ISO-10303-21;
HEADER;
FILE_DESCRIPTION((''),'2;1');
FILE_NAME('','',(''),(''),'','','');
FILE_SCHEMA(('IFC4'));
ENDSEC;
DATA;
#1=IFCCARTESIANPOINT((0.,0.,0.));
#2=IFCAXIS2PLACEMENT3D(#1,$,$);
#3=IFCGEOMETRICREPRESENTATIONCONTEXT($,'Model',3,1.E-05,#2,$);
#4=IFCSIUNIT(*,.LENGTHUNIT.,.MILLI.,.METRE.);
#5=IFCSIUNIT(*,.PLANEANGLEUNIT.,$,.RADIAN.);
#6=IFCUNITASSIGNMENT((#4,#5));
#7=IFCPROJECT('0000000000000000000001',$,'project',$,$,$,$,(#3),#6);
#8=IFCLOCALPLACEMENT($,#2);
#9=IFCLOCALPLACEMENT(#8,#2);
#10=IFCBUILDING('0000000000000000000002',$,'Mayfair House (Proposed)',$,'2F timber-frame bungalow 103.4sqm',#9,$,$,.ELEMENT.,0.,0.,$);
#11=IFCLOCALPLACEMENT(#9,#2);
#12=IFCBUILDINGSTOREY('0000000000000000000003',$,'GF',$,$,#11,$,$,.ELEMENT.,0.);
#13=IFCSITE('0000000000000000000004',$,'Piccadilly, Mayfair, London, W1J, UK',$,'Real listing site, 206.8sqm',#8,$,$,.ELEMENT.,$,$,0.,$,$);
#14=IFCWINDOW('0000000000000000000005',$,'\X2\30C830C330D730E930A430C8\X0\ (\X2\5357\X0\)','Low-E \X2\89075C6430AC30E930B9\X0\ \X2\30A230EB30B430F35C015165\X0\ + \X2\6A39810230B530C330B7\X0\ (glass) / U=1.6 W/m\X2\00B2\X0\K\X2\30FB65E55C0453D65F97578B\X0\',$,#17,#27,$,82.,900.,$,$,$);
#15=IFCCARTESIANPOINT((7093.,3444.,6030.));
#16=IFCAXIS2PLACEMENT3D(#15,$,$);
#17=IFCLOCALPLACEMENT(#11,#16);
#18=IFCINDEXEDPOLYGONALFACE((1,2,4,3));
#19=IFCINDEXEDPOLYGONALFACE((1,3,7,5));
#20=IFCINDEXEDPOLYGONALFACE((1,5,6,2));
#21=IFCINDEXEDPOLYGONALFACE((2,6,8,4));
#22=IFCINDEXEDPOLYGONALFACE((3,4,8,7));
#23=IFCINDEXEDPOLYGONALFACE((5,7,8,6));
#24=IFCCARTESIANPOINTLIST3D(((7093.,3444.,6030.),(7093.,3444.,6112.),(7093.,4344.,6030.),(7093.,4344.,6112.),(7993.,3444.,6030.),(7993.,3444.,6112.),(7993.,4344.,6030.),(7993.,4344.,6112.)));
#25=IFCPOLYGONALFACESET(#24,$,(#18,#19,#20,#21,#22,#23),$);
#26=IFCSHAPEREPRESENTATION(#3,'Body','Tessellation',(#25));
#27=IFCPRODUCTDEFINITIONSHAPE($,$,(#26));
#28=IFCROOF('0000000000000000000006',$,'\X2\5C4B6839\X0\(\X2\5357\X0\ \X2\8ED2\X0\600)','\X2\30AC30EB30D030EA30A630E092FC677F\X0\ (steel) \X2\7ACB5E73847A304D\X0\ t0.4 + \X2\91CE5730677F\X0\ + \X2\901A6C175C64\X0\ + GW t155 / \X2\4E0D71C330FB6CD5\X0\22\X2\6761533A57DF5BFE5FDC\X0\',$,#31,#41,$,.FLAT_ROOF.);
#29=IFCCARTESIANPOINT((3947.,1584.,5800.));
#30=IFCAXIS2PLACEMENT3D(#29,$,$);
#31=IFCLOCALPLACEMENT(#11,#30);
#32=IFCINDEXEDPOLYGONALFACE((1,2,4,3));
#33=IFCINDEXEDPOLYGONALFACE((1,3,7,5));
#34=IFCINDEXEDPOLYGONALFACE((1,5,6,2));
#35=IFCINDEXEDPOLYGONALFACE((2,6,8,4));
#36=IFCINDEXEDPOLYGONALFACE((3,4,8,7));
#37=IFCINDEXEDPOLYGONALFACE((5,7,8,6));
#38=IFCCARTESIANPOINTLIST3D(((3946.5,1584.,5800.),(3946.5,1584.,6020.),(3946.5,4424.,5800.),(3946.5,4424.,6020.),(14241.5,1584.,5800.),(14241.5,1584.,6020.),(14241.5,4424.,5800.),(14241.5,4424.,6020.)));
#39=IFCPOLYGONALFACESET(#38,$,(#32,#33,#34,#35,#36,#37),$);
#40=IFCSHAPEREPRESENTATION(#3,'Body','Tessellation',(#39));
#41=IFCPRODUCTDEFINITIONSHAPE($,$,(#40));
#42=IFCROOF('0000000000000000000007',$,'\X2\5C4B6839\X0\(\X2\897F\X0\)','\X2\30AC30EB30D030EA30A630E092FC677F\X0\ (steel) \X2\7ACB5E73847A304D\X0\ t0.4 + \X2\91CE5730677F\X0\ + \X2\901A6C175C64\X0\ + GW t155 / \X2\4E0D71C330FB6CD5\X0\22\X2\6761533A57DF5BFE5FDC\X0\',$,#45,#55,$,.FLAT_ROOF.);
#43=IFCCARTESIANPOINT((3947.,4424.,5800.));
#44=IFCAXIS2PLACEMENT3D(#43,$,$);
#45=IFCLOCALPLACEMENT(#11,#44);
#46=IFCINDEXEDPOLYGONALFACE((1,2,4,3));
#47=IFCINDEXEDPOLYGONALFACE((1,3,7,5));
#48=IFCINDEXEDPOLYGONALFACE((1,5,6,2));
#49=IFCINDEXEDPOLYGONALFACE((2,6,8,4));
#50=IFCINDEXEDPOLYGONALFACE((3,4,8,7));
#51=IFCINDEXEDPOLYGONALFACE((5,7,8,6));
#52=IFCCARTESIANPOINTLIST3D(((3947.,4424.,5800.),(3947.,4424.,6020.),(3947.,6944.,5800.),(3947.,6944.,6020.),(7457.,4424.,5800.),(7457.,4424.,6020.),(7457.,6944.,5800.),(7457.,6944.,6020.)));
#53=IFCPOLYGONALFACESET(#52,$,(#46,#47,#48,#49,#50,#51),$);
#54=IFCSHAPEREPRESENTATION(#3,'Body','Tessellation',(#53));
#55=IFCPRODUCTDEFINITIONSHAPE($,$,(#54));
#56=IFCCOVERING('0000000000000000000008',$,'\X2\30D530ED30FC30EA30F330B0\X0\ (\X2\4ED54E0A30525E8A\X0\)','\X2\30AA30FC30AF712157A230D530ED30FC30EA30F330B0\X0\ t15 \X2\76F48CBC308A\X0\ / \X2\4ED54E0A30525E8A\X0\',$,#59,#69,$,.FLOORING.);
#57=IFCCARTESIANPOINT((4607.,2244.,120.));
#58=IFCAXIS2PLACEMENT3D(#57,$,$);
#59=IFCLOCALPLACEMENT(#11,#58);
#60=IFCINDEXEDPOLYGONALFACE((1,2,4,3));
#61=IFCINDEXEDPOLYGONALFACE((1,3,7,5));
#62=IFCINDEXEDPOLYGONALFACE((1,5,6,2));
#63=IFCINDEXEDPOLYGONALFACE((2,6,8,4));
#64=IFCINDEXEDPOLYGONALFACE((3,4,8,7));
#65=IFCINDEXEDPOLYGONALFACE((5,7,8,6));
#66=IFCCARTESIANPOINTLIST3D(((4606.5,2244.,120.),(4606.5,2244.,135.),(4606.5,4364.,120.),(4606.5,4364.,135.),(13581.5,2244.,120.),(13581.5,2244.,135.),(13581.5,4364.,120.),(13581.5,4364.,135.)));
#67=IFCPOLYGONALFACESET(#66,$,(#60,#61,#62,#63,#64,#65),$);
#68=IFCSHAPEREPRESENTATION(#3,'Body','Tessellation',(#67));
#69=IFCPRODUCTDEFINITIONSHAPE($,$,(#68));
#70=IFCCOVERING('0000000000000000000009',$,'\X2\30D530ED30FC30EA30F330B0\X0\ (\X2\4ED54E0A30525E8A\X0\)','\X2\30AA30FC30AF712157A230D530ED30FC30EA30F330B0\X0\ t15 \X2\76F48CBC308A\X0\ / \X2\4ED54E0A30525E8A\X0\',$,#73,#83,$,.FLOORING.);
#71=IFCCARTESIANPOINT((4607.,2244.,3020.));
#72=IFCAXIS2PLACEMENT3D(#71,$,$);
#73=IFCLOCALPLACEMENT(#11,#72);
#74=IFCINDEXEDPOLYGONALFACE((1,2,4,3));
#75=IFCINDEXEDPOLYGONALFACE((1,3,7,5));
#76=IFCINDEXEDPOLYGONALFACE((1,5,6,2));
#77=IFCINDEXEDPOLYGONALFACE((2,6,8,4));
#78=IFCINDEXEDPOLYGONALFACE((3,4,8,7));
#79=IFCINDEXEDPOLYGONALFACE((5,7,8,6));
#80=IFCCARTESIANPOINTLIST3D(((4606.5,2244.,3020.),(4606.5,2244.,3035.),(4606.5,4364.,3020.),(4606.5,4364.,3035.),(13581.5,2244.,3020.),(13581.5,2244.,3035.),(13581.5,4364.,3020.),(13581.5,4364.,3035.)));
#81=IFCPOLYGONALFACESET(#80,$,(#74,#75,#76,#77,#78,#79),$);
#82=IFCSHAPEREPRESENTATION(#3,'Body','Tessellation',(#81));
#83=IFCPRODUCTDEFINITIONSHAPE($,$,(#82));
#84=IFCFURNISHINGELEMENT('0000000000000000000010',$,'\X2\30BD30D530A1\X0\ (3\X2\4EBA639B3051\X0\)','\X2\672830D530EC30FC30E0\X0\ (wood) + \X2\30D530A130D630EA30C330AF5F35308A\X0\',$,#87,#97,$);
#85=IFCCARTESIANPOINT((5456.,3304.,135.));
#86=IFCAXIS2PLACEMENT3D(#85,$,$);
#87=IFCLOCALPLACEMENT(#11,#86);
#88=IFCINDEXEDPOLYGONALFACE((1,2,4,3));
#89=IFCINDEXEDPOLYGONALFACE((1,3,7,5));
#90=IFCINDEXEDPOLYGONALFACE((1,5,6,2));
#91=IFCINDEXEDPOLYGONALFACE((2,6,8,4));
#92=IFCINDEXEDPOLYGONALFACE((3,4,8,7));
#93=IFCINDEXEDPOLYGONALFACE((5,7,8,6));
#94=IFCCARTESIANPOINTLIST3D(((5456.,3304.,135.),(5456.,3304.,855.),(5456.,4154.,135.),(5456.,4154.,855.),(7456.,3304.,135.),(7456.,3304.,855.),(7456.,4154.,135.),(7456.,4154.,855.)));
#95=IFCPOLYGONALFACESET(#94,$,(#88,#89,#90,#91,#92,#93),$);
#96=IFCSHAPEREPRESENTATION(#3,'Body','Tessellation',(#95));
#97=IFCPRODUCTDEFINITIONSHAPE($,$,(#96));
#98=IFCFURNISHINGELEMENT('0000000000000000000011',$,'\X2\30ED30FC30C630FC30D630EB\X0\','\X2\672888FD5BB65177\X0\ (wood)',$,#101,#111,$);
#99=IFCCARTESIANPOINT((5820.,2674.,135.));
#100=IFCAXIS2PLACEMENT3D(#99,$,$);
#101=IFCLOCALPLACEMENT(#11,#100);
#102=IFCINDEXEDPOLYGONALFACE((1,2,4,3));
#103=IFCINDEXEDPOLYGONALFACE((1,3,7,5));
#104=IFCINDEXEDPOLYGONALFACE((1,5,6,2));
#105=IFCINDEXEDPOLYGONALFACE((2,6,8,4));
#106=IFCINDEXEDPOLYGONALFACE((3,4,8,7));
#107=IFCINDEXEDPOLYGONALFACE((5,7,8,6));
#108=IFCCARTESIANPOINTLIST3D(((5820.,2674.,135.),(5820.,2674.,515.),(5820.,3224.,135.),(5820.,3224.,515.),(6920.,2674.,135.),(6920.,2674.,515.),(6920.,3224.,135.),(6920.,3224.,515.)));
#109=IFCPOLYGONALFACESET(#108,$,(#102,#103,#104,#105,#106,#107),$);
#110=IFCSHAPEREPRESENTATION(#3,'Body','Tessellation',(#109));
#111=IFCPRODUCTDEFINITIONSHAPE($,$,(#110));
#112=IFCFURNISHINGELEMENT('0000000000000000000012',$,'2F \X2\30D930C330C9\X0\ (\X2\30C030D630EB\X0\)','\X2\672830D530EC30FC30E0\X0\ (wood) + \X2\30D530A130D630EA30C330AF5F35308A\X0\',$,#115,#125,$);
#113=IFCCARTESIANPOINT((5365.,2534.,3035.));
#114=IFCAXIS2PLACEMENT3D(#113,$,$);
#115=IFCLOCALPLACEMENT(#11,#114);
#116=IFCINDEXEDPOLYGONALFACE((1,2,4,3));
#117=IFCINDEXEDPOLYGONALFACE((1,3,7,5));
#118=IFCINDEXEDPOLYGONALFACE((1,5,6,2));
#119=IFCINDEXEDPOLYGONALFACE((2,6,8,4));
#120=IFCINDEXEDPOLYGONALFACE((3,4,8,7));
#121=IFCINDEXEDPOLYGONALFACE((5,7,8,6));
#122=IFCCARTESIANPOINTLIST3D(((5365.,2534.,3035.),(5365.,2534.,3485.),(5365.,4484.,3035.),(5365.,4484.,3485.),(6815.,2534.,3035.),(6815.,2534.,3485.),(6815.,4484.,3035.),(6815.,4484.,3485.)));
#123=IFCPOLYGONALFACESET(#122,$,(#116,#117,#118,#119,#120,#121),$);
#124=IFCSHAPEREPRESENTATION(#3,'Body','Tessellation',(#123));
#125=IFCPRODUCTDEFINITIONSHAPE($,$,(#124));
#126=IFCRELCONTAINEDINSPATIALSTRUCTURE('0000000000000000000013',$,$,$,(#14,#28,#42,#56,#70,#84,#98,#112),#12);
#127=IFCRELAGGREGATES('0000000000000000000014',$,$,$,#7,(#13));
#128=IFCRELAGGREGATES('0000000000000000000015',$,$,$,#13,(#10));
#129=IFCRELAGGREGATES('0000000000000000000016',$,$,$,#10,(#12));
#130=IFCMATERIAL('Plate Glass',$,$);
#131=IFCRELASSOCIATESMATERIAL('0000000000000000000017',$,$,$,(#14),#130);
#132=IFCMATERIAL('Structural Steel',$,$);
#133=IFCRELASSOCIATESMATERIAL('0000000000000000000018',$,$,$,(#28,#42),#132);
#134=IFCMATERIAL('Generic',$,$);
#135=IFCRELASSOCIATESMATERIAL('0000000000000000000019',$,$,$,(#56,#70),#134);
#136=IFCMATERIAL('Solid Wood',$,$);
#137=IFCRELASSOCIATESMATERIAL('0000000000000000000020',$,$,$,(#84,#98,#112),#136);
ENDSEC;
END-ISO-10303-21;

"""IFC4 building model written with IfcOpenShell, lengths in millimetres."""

from ifc_helpers import new_model, si_unit, frame, frame_2d, origin, place, context, project, spatial, rectangle, extrude, material, element, save


model = new_model("IFC4")

# Units and contexts
model_context = context("Model", 3, precision=1e-05, world=origin())
ifc_project = project(units=[si_unit("LENGTHUNIT", "METRE", prefix="MILLI"), si_unit("PLANEANGLEUNIT", "RADIAN")], contexts=[model_context])

# Site, building, storey
site_placement = place(None, origin())
site = spatial("IfcSite", under=ifc_project, at=site_placement, Name="Piccadilly, Mayfair, London, W1J, UK", ObjectType="Real listing site, 206.8sqm", CompositionType="ELEMENT", RefElevation=0.0)
building_placement = place(site_placement, origin())
building = spatial("IfcBuilding", under=site, at=building_placement, Name="Mayfair House (Proposed)", ObjectType="2F timber-frame bungalow 103.4sqm", CompositionType="ELEMENT", ElevationOfRefHeight=0.0, ElevationOfTerrain=0.0)
storey_placement = place(building_placement, origin())
storey = spatial("IfcBuildingStorey", under=building, at=storey_placement, Name="GF", CompositionType="ELEMENT", Elevation=0.0)

# Shared definitions
ifc_material_1 = material(Name="Solid Wood")

# Shared definitions
ifc_material_2 = material(Name="Plate Glass")

# Window
window_1_placement = place(storey_placement, frame((7093.0, 3444.0, 6030.0)))
element("IfcWindow", 1, at=window_1_placement, inside=storey, material=ifc_material_2, Name="トップライト (南)", Description="Low-E 複層ガラス アルゴン封入 + 樹脂サッシ (glass) / U=1.6 W/m²K・日射取得型", OverallHeight=82.0, OverallWidth=900.0, context=model_context, shape_type="SweptSolid", body=[
    extrude(rectangle(XDim=900.0, YDim=900.0, at=frame_2d((450.0, 450.0))), frame((7093.0, 3444.0, 6030.0)), (0.0, 0.0, 1.0), 82.0),
])

# Roofs
ifc_material_3 = material(Name="Structural Steel")
roof_1_placement = place(storey_placement, frame((3947.0, 1584.0, 5800.0)))
element("IfcRoof", 2, at=roof_1_placement, inside=storey, material=ifc_material_3, Name="屋根(南 軒600)", Description="ガルバリウム鋼板 (steel) 立平葺き t0.4 + 野地板 + 通気層 + GW t155 / 不燃・法22条区域対応", PredefinedType="FLAT_ROOF", context=model_context, shape_type="SweptSolid", body=[
    extrude(rectangle(XDim=10295.0, YDim=2840.0, at=frame_2d((5147.0, 1420.0))), frame((3947.0, 1584.0, 5800.0)), (0.0, 0.0, 1.0), 220.0),
])
roof_2_placement = place(storey_placement, frame((3947.0, 4424.0, 5800.0)))
element("IfcRoof", 3, at=roof_2_placement, inside=storey, material=ifc_material_3, Name="屋根(西)", Description="ガルバリウム鋼板 (steel) 立平葺き t0.4 + 野地板 + 通気層 + GW t155 / 不燃・法22条区域対応", PredefinedType="FLAT_ROOF", context=model_context, shape_type="SweptSolid", body=[
    extrude(rectangle(XDim=3510.0, YDim=2520.0, at=frame_2d((1755.0, 1260.0))), frame((3947.0, 4424.0, 5800.0)), (0.0, 0.0, 1.0), 220.0),
])

# Coverings
ifc_material_4 = material(Name="Generic")
covering_1_placement = place(storey_placement, frame((4607.0, 2244.0, 120.0)))
element("IfcCovering", 4, at=covering_1_placement, inside=storey, material=ifc_material_4, Name="フローリング (仕上げ床)", Description="オーク無垢フローリング t15 直貼り / 仕上げ床", PredefinedType="FLOORING", context=model_context, shape_type="SweptSolid", body=[
    extrude(rectangle(XDim=8975.0, YDim=2120.0, at=frame_2d((4487.0, 1060.0))), frame((4607.0, 2244.0, 120.0)), (0.0, 0.0, 1.0), 15.0),
])
covering_2_placement = place(storey_placement, frame((4607.0, 2244.0, 3020.0)))
element("IfcCovering", 5, at=covering_2_placement, inside=storey, material=ifc_material_4, Name="フローリング (仕上げ床)", Description="オーク無垢フローリング t15 直貼り / 仕上げ床", PredefinedType="FLOORING", context=model_context, shape_type="SweptSolid", body=[
    extrude(rectangle(XDim=8975.0, YDim=2120.0, at=frame_2d((4487.0, 1060.0))), frame((4607.0, 2244.0, 3020.0)), (0.0, 0.0, 1.0), 15.0),
])

# Furnishing elements
furnishing_1_placement = place(storey_placement, frame((5456.0, 3304.0, 135.0)))
element("IfcFurnishingElement", 6, at=furnishing_1_placement, inside=storey, material=ifc_material_1, Name="ソファ (3人掛け)", Description="木フレーム (wood) + ファブリック張り", context=model_context, shape_type="SweptSolid", body=[
    extrude(rectangle(XDim=2000.0, YDim=850.0, at=frame_2d((1000.0, 425.0))), frame((5456.0, 3304.0, 135.0)), (0.0, 0.0, 1.0), 720.0),
])
furnishing_2_placement = place(storey_placement, frame((5820.0, 2674.0, 135.0)))
element("IfcFurnishingElement", 7, at=furnishing_2_placement, inside=storey, material=ifc_material_1, Name="ローテーブル", Description="木製家具 (wood)", context=model_context, shape_type="SweptSolid", body=[
    extrude(rectangle(XDim=1100.0, YDim=550.0, at=frame_2d((550.0, 275.0))), frame((5820.0, 2674.0, 135.0)), (0.0, 0.0, 1.0), 380.0),
])
furnishing_3_placement = place(storey_placement, frame((5365.0, 2534.0, 3035.0)))
element("IfcFurnishingElement", 8, at=furnishing_3_placement, inside=storey, material=ifc_material_1, Name="2F ベッド (ダブル)", Description="木フレーム (wood) + ファブリック張り", context=model_context, shape_type="SweptSolid", body=[
    extrude(rectangle(XDim=1450.0, YDim=1950.0, at=frame_2d((725.0, 975.0))), frame((5365.0, 2534.0, 3035.0)), (0.0, 0.0, 1.0), 450.0),
])

save(model, "model.ifc")
